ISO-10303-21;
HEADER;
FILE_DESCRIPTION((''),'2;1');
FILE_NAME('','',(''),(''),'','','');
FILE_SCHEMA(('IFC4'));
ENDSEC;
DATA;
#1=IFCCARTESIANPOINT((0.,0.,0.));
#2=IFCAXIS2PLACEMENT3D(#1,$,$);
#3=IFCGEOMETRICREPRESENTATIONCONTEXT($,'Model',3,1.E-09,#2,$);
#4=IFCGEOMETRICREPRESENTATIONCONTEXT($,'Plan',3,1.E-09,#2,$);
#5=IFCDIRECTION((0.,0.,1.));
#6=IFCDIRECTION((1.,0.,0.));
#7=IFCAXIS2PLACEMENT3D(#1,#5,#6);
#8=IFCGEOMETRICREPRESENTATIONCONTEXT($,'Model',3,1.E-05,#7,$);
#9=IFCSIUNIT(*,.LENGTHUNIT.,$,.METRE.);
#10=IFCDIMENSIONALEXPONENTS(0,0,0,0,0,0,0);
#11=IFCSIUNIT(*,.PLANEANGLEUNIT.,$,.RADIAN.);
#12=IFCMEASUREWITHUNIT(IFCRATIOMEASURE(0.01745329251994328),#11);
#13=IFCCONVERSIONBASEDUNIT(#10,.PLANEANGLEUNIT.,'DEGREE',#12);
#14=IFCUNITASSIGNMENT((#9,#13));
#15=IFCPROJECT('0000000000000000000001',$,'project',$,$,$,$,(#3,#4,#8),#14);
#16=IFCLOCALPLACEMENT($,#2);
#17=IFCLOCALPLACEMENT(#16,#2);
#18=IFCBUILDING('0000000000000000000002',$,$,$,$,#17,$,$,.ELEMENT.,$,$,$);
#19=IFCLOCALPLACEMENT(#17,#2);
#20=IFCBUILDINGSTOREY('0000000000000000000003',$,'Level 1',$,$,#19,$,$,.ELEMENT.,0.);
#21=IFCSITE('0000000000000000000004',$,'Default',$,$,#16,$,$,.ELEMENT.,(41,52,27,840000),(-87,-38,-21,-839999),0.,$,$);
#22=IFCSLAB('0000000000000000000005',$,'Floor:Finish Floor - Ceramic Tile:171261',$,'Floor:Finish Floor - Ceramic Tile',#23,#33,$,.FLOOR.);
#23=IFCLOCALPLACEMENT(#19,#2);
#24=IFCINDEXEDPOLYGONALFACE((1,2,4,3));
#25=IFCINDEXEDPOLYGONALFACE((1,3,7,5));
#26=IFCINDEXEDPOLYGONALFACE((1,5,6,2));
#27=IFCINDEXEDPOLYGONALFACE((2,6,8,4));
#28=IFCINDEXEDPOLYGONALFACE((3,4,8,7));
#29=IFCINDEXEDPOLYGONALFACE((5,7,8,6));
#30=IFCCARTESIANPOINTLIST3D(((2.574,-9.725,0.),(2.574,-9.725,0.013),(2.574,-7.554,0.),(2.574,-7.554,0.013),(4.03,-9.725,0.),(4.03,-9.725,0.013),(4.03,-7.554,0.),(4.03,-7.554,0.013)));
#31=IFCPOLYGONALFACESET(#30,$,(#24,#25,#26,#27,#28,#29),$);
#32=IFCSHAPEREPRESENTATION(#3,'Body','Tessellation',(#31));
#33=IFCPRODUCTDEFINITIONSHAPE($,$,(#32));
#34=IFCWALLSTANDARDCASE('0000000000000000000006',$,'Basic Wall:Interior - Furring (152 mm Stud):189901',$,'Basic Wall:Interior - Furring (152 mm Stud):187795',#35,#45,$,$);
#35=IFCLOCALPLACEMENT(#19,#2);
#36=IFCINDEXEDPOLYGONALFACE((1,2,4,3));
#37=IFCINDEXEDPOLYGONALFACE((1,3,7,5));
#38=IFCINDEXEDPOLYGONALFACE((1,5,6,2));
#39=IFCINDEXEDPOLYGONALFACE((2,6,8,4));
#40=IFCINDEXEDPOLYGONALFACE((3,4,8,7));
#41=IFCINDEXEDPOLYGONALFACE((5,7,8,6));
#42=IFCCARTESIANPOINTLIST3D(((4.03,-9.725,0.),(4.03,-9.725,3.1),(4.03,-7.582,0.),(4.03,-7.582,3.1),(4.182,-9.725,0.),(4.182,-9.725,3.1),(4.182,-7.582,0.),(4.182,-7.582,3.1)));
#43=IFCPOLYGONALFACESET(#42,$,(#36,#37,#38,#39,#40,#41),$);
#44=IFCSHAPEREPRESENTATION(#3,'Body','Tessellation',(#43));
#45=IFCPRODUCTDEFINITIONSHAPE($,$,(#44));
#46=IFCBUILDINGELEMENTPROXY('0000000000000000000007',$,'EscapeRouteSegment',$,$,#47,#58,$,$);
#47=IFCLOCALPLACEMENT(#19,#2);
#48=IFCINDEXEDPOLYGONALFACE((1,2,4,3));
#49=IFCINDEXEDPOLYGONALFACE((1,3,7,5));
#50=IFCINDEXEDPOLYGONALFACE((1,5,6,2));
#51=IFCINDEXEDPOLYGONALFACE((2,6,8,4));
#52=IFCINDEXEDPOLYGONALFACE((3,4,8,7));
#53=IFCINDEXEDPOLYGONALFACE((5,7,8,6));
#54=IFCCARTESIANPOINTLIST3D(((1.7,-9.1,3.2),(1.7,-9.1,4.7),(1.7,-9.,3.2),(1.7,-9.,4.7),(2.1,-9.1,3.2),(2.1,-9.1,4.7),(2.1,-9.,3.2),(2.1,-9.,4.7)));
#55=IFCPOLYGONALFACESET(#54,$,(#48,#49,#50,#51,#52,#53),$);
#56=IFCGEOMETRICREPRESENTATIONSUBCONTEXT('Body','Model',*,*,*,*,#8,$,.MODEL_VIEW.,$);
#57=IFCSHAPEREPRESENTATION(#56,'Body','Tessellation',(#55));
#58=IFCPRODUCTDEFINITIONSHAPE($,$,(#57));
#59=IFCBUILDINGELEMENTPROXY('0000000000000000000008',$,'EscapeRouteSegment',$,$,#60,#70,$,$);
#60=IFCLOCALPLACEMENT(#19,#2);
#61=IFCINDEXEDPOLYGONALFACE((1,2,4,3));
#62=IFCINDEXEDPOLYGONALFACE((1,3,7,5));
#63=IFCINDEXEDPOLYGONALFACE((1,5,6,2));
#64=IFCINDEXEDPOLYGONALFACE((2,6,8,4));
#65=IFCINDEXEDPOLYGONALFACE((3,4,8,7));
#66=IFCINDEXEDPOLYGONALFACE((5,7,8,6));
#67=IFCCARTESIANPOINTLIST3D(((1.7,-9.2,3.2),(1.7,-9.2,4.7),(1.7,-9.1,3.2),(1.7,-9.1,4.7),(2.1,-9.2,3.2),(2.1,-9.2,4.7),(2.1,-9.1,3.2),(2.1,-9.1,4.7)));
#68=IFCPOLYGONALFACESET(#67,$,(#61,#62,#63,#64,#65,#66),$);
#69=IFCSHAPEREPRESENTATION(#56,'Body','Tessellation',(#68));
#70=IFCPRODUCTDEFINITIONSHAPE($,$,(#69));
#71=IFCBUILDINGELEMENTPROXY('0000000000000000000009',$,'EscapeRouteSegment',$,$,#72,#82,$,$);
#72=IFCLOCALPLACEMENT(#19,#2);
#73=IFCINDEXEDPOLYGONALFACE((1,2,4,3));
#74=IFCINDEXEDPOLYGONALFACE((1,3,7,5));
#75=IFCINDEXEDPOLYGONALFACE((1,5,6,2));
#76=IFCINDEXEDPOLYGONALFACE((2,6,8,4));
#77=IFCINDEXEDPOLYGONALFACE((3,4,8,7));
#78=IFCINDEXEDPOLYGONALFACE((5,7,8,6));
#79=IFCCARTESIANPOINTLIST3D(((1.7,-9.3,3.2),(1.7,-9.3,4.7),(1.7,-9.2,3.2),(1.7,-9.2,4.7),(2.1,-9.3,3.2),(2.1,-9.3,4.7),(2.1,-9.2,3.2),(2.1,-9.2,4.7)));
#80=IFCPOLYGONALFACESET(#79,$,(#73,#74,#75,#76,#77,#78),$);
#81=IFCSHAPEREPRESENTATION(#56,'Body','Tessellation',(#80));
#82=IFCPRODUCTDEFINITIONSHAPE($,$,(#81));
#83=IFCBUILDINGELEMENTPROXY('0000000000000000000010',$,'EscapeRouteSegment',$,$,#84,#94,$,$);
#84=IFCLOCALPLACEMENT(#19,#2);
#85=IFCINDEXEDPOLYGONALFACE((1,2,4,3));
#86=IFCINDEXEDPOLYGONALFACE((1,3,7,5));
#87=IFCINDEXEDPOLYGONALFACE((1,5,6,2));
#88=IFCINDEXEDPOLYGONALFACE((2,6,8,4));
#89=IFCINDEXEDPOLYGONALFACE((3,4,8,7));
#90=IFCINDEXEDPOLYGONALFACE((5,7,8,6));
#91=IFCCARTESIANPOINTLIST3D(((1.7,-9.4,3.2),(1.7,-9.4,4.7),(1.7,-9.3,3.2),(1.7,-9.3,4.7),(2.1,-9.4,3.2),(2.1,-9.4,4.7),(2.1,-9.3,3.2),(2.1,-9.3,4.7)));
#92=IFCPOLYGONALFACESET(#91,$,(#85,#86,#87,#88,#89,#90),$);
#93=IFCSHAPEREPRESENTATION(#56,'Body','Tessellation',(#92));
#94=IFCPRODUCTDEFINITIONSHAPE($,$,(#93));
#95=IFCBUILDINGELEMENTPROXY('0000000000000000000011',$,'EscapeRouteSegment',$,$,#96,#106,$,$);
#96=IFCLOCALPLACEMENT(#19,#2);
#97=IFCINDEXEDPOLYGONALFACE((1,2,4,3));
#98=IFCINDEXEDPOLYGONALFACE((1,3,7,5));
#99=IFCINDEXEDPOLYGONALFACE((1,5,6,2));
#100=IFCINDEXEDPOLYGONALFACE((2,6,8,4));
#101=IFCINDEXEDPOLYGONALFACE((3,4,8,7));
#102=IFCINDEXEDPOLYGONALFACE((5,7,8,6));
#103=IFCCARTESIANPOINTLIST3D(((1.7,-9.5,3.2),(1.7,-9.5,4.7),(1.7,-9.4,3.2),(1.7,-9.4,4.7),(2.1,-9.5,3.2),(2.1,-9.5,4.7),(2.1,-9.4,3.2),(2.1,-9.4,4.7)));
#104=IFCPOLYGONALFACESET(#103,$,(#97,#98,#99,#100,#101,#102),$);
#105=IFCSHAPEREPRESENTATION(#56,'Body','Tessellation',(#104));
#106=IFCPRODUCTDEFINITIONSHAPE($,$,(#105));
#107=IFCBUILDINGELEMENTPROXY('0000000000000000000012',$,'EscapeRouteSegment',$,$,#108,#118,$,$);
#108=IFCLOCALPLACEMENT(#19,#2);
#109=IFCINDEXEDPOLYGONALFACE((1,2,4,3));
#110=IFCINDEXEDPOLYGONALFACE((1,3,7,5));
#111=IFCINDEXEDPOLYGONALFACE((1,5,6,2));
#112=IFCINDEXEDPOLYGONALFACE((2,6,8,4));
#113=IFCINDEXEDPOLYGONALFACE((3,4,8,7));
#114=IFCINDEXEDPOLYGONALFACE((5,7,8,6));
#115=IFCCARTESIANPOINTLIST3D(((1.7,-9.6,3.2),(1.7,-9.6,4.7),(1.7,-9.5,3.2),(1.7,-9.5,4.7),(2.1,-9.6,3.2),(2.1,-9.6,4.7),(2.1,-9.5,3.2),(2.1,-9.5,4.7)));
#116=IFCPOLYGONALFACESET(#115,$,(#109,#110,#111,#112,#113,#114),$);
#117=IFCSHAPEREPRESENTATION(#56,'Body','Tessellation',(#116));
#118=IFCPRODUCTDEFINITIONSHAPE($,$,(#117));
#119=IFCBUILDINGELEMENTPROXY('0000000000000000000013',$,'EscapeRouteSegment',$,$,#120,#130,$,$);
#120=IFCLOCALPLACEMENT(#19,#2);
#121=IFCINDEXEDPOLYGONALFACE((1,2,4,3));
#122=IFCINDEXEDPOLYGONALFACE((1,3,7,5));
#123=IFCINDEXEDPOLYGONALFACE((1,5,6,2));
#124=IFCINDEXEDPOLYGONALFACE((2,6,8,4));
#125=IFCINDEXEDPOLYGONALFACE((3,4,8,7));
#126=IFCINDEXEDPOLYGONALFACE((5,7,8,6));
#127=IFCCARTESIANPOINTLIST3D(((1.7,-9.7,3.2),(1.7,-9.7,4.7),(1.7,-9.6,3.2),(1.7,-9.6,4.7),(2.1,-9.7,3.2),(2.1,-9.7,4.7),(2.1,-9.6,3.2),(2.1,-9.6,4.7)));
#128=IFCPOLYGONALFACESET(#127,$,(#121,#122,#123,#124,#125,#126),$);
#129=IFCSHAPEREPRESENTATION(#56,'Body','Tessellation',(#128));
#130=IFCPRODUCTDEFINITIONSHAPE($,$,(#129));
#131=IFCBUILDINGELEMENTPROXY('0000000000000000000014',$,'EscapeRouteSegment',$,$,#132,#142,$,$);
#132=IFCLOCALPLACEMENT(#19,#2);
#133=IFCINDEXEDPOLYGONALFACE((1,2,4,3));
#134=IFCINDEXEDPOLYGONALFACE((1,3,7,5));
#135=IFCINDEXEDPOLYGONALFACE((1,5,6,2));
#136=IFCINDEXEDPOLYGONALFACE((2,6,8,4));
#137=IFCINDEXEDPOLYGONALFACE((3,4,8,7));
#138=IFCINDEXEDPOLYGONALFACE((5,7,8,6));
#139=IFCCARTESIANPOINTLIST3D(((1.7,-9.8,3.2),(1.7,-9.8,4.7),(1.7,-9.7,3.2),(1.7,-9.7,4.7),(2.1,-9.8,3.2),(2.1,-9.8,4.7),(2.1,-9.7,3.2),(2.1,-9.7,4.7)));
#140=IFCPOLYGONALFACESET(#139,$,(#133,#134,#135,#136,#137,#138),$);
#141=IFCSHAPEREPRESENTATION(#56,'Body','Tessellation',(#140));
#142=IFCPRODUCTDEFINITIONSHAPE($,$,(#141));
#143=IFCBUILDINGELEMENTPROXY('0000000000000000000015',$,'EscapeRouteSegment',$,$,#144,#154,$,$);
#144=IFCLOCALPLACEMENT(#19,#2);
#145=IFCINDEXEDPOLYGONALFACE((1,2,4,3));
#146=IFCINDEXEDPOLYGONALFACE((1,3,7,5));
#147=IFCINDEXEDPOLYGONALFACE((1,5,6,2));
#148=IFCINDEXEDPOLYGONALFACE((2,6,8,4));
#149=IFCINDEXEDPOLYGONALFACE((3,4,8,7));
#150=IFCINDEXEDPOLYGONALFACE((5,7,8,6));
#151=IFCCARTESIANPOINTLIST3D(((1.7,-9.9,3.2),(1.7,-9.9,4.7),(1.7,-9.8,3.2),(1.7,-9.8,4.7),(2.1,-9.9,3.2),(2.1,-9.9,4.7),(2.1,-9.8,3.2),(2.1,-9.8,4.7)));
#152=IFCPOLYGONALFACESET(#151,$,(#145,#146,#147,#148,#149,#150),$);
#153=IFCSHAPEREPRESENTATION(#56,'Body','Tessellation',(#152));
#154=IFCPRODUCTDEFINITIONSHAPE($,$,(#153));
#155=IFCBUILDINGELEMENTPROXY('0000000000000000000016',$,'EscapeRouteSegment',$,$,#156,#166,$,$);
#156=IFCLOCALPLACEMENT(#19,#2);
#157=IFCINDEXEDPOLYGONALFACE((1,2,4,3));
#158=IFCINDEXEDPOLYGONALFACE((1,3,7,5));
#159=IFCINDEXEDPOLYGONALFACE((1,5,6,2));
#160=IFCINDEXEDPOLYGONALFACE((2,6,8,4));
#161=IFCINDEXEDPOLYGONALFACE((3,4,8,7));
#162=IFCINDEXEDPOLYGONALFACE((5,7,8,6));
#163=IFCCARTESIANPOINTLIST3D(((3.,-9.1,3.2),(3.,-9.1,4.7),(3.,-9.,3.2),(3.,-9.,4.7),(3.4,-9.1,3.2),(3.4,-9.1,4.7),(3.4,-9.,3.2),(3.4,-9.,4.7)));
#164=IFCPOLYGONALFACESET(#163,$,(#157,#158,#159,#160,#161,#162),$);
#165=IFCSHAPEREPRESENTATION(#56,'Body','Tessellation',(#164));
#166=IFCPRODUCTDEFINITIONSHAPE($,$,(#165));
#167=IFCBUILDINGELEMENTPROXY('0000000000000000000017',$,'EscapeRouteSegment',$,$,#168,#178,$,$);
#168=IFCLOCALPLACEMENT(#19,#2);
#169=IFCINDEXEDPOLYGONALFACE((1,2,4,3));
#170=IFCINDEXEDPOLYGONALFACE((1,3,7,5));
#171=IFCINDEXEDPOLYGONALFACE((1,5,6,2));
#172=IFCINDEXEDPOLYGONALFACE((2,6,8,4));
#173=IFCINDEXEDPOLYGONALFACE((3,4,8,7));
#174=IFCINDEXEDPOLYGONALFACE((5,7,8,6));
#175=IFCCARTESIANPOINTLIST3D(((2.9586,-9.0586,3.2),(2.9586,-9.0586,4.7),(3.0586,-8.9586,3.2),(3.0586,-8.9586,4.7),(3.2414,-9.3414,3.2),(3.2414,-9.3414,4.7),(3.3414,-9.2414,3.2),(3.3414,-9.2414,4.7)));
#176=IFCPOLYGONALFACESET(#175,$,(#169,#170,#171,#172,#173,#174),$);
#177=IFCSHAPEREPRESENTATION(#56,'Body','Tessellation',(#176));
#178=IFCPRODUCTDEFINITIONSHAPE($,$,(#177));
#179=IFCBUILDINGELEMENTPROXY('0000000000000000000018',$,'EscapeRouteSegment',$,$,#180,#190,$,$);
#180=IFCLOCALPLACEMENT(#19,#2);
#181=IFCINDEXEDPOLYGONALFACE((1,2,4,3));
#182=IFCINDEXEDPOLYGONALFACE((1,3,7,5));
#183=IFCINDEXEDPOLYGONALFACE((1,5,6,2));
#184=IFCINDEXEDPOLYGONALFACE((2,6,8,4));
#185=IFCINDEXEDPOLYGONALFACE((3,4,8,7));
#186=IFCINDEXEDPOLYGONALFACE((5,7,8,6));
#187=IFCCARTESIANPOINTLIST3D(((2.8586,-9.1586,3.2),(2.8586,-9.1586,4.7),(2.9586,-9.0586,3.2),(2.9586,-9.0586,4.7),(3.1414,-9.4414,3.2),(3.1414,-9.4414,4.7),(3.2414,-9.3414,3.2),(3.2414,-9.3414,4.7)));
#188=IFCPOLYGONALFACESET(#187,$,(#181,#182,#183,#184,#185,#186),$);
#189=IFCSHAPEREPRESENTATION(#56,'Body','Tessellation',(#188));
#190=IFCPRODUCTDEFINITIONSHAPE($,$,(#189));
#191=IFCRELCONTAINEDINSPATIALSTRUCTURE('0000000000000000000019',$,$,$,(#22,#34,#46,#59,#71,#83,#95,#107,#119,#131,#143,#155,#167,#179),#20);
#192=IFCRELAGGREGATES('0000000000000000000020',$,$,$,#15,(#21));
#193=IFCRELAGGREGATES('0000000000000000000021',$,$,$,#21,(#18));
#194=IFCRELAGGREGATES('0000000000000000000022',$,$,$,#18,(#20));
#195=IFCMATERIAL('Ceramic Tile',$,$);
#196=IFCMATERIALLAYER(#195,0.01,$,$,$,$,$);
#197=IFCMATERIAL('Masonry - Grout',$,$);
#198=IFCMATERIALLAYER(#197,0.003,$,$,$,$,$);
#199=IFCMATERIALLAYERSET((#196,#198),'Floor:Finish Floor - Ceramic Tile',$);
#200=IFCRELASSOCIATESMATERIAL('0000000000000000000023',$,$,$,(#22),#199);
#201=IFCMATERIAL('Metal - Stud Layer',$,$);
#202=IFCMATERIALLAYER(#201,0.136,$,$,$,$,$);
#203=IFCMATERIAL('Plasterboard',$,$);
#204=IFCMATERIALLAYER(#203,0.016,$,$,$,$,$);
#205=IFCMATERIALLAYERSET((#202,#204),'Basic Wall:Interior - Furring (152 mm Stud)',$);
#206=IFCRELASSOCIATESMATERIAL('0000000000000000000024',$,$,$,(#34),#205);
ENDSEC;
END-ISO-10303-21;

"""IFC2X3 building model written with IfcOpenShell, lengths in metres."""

from ifc_helpers import new_model, entity, si_unit, converted_unit, frame, frame_2d, origin, origin_with_axes, place, context, subcontext, project, spatial, polyline, rectangle, outline, extrude, material, layer, layer_set, layer_usage, element, save


model = new_model("IFC2X3")

# Units and contexts
model_context_1 = context("Model", 3, precision=1e-09, world=origin())
plan_context = context("Plan", 3, precision=1e-09, world=origin())
model_context_2 = context("Model", 3, precision=1e-05, world=origin_with_axes())
body_context = subcontext(model_context_2, "Body", "Model", "MODEL_VIEW")
ifc_project = project(units=[si_unit("LENGTHUNIT", "METRE"), converted_unit("PLANEANGLEUNIT", "DEGREE", entity("IfcRatioMeasure", 0.01745329251994328), si_unit("PLANEANGLEUNIT", "RADIAN"), dimensions=[0, 0, 0, 0, 0, 0, 0])], contexts=[model_context_1, plan_context, model_context_2])

# Site, building, storey
site_placement = place(None, origin())
site = spatial("IfcSite", under=ifc_project, at=site_placement, Name="Default", CompositionType="ELEMENT", RefLatitude=(41, 52, 27, 840000), RefLongitude=(-87, -38, -21, -839999), RefElevation=0.0)
building_placement = place(site_placement, origin())
building = spatial("IfcBuilding", under=site, at=building_placement, CompositionType="ELEMENT")
storey_placement = place(building_placement, origin())
storey = spatial("IfcBuildingStorey", under=building, at=storey_placement, Name="Level 1", CompositionType="ELEMENT", Elevation=0.0)

# Slab
ifc_material_1 = material(Name="Ceramic Tile")
ifc_layer_1 = layer(ifc_material_1, 0.01)
ifc_material_2 = material(Name="Masonry - Grout")
ifc_layer_2 = layer(ifc_material_2, 0.003)
ifc_layer_set_1 = layer_set([ifc_layer_1, ifc_layer_2], Name="Floor:Finish Floor - Ceramic Tile")
ifc_layer_usage_1 = layer_usage(ifc_layer_set_1, "AXIS3", "POSITIVE", 0.0)
slab_placement = place(storey_placement, frame((2.574, -9.725, 0.0)))
element("IfcSlab", 1, at=slab_placement, inside=storey, material=ifc_layer_usage_1, Name="Floor:Finish Floor - Ceramic Tile:171261", ObjectType="Floor:Finish Floor - Ceramic Tile", PredefinedType="FLOOR", context=model_context_1, shape_type="SweptSolid", body=[
    extrude(rectangle(XDim=2.171, YDim=1.456, at=frame_2d((0.0, 0.0), x_axis=(0.0, -1.0))), frame((0.728, 1.0855, 0.013), z_axis=(0.0, 0.0, -1.0), x_axis=(-1.0, 0.0, 0.0)), (0.0, 0.0, 1.0), 0.013),
])

# Wall
ifc_material_3 = material(Name="Metal - Stud Layer")
ifc_layer_3 = layer(ifc_material_3, 0.136)
ifc_material_4 = material(Name="Plasterboard")
ifc_layer_4 = layer(ifc_material_4, 0.016)
ifc_layer_set_2 = layer_set([ifc_layer_3, ifc_layer_4], Name="Basic Wall:Interior - Furring (152 mm Stud)")
ifc_layer_usage_2 = layer_usage(ifc_layer_set_2, "AXIS2", "POSITIVE", -0.076)
wall_placement = place(storey_placement, frame((4.106, -9.725, 0.0), z_axis=(0.0, 0.0, 1.0), x_axis=(0.0, 1.0, 0.0)))
element("IfcWallStandardCase", 2, at=wall_placement, inside=storey, material=ifc_layer_usage_2, Name="Basic Wall:Interior - Furring (152 mm Stud):189901", ObjectType="Basic Wall:Interior - Furring (152 mm Stud):187795", context=model_context_1, shape_type="SweptSolid", body=[
    extrude(rectangle(XDim=2.143, YDim=0.152, at=frame_2d((1.0715, 0.0), x_axis=(-1.0, 0.0))), origin(), (0.0, 0.0, 1.0), 3.1),
])

# Building element proxies
proxy_1_placement = place(storey_placement, frame((1.9, -9.0, 3.2), z_axis=(0.0, 0.0, 1.0), x_axis=(0.0, -1.0, 0.0)))
element("IfcBuildingElementProxy", 3, at=proxy_1_placement, inside=storey, Name="EscapeRouteSegment", context=body_context, shape_type="SweptSolid", body=[
    extrude(outline(polyline([(0.0, -0.2), (0.0, 0.2), (0.1, 0.2), (0.1, -0.2), (0.0, -0.2)])), origin_with_axes(), (0.0, 0.0, 1.0), 1.5),
])
proxy_2_placement = place(storey_placement, frame((1.9, -9.1, 3.2), z_axis=(0.0, 0.0, 1.0), x_axis=(0.0, -1.0, 0.0)))
element("IfcBuildingElementProxy", 4, at=proxy_2_placement, inside=storey, Name="EscapeRouteSegment", context=body_context, shape_type="SweptSolid", body=[
    extrude(outline(polyline([(0.0, -0.2), (0.0, 0.2), (0.1, 0.2), (0.1, -0.2), (0.0, -0.2)])), origin_with_axes(), (0.0, 0.0, 1.0), 1.5),
])
proxy_3_placement = place(storey_placement, frame((1.9, -9.2, 3.2), z_axis=(0.0, 0.0, 1.0), x_axis=(0.0, -1.0, 0.0)))
element("IfcBuildingElementProxy", 5, at=proxy_3_placement, inside=storey, Name="EscapeRouteSegment", context=body_context, shape_type="SweptSolid", body=[
    extrude(outline(polyline([(0.0, -0.2), (0.0, 0.2), (0.1, 0.2), (0.1, -0.2), (0.0, -0.2)])), origin_with_axes(), (0.0, 0.0, 1.0), 1.5),
])
proxy_4_placement = place(storey_placement, frame((1.9, -9.3, 3.2), z_axis=(0.0, 0.0, 1.0), x_axis=(0.0, -1.0, 0.0)))
element("IfcBuildingElementProxy", 6, at=proxy_4_placement, inside=storey, Name="EscapeRouteSegment", context=body_context, shape_type="SweptSolid", body=[
    extrude(outline(polyline([(0.0, -0.2), (0.0, 0.2), (0.1, 0.2), (0.1, -0.2), (0.0, -0.2)])), origin_with_axes(), (0.0, 0.0, 1.0), 1.5),
])
for number, where, z_axis, x_axis, name in (
    (7, (1.9, -9.4, 3.2), (0.0, 0.0, 1.0), (0.0, -1.0, 0.0), "EscapeRouteSegment"),
    (8, (1.9, -9.5, 3.2), (0.0, 0.0, 1.0), (0.0, -1.0, 0.0), "EscapeRouteSegment"),
):
    element("IfcBuildingElementProxy", number, at=place(storey_placement, frame(where, z_axis=z_axis, x_axis=x_axis)), inside=storey, Name=name, context=body_context, shape_type="SweptSolid", body=[
        extrude(outline(polyline([(0.0, -0.2), (0.0, 0.2), (0.1, 0.2), (0.1, -0.2), (0.0, -0.2)])), origin_with_axes(), (0.0, 0.0, 1.0), 1.5),
    ])
proxy_5_placement = place(storey_placement, frame((1.9, -9.6, 3.2), z_axis=(0.0, 0.0, 1.0), x_axis=(0.0, -1.0, 0.0)))
element("IfcBuildingElementProxy", 9, at=proxy_5_placement, inside=storey, Name="EscapeRouteSegment", context=body_context, shape_type="SweptSolid", body=[
    extrude(outline(polyline([(0.0, -0.2), (0.0, 0.2), (0.1, 0.2), (0.1, -0.2), (0.0, -0.2)])), origin_with_axes(), (0.0, 0.0, 1.0), 1.5),
])
proxy_6_placement = place(storey_placement, frame((1.9, -9.7, 3.2), z_axis=(0.0, 0.0, 1.0), x_axis=(0.0, -1.0, 0.0)))
element("IfcBuildingElementProxy", 10, at=proxy_6_placement, inside=storey, Name="EscapeRouteSegment", context=body_context, shape_type="SweptSolid", body=[
    extrude(outline(polyline([(0.0, -0.2), (0.0, 0.2), (0.1, 0.2), (0.1, -0.2), (0.0, -0.2)])), origin_with_axes(), (0.0, 0.0, 1.0), 1.5),
])
proxy_7_placement = place(storey_placement, frame((1.9, -9.8, 3.2), z_axis=(0.0, 0.0, 1.0), x_axis=(0.0, -1.0, 0.0)))
element("IfcBuildingElementProxy", 11, at=proxy_7_placement, inside=storey, Name="EscapeRouteSegment", context=body_context, shape_type="SweptSolid", body=[
    extrude(outline(polyline([(0.0, -0.2), (0.0, 0.2), (0.1, 0.2), (0.1, -0.2), (0.0, -0.2)])), origin_with_axes(), (0.0, 0.0, 1.0), 1.5),
])
proxy_8_placement = place(storey_placement, frame((3.2, -9.0, 3.2), z_axis=(0.0, 0.0, 1.0), x_axis=(0.0, -1.0, 0.0)))
element("IfcBuildingElementProxy", 12, at=proxy_8_placement, inside=storey, Name="EscapeRouteSegment", context=body_context, shape_type="SweptSolid", body=[
    extrude(outline(polyline([(0.0, -0.2), (0.0, 0.2), (0.1, 0.2), (0.1, -0.2), (0.0, -0.2)])), origin_with_axes(), (0.0, 0.0, 1.0), 1.5),
])
proxy_9_placement = place(storey_placement, frame((3.2, -9.1, 3.2), z_axis=(0.0, 0.0, 1.0), x_axis=(-0.707109, -0.707104, 0.0)))
element("IfcBuildingElementProxy", 13, at=proxy_9_placement, inside=storey, Name="EscapeRouteSegment", context=body_context, shape_type="SweptSolid", body=[
    extrude(outline(polyline([(0.0, -0.2), (0.0, 0.2), (0.1414, 0.2), (0.1414, -0.2), (0.0, -0.2)])), origin_with_axes(), (0.0, 0.0, 1.0), 1.5),
])
proxy_10_placement = place(storey_placement, frame((3.1, -9.2, 3.2), z_axis=(0.0, 0.0, 1.0), x_axis=(-0.707105, -0.707108, 0.0)))
element("IfcBuildingElementProxy", 14, at=proxy_10_placement, inside=storey, Name="EscapeRouteSegment", context=body_context, shape_type="SweptSolid", body=[
    extrude(outline(polyline([(0.0, -0.2), (0.0, 0.2), (0.1414, 0.2), (0.1414, -0.2), (0.0, -0.2)])), origin_with_axes(), (0.0, 0.0, 1.0), 1.5),
])

save(model, "model.ifc")
